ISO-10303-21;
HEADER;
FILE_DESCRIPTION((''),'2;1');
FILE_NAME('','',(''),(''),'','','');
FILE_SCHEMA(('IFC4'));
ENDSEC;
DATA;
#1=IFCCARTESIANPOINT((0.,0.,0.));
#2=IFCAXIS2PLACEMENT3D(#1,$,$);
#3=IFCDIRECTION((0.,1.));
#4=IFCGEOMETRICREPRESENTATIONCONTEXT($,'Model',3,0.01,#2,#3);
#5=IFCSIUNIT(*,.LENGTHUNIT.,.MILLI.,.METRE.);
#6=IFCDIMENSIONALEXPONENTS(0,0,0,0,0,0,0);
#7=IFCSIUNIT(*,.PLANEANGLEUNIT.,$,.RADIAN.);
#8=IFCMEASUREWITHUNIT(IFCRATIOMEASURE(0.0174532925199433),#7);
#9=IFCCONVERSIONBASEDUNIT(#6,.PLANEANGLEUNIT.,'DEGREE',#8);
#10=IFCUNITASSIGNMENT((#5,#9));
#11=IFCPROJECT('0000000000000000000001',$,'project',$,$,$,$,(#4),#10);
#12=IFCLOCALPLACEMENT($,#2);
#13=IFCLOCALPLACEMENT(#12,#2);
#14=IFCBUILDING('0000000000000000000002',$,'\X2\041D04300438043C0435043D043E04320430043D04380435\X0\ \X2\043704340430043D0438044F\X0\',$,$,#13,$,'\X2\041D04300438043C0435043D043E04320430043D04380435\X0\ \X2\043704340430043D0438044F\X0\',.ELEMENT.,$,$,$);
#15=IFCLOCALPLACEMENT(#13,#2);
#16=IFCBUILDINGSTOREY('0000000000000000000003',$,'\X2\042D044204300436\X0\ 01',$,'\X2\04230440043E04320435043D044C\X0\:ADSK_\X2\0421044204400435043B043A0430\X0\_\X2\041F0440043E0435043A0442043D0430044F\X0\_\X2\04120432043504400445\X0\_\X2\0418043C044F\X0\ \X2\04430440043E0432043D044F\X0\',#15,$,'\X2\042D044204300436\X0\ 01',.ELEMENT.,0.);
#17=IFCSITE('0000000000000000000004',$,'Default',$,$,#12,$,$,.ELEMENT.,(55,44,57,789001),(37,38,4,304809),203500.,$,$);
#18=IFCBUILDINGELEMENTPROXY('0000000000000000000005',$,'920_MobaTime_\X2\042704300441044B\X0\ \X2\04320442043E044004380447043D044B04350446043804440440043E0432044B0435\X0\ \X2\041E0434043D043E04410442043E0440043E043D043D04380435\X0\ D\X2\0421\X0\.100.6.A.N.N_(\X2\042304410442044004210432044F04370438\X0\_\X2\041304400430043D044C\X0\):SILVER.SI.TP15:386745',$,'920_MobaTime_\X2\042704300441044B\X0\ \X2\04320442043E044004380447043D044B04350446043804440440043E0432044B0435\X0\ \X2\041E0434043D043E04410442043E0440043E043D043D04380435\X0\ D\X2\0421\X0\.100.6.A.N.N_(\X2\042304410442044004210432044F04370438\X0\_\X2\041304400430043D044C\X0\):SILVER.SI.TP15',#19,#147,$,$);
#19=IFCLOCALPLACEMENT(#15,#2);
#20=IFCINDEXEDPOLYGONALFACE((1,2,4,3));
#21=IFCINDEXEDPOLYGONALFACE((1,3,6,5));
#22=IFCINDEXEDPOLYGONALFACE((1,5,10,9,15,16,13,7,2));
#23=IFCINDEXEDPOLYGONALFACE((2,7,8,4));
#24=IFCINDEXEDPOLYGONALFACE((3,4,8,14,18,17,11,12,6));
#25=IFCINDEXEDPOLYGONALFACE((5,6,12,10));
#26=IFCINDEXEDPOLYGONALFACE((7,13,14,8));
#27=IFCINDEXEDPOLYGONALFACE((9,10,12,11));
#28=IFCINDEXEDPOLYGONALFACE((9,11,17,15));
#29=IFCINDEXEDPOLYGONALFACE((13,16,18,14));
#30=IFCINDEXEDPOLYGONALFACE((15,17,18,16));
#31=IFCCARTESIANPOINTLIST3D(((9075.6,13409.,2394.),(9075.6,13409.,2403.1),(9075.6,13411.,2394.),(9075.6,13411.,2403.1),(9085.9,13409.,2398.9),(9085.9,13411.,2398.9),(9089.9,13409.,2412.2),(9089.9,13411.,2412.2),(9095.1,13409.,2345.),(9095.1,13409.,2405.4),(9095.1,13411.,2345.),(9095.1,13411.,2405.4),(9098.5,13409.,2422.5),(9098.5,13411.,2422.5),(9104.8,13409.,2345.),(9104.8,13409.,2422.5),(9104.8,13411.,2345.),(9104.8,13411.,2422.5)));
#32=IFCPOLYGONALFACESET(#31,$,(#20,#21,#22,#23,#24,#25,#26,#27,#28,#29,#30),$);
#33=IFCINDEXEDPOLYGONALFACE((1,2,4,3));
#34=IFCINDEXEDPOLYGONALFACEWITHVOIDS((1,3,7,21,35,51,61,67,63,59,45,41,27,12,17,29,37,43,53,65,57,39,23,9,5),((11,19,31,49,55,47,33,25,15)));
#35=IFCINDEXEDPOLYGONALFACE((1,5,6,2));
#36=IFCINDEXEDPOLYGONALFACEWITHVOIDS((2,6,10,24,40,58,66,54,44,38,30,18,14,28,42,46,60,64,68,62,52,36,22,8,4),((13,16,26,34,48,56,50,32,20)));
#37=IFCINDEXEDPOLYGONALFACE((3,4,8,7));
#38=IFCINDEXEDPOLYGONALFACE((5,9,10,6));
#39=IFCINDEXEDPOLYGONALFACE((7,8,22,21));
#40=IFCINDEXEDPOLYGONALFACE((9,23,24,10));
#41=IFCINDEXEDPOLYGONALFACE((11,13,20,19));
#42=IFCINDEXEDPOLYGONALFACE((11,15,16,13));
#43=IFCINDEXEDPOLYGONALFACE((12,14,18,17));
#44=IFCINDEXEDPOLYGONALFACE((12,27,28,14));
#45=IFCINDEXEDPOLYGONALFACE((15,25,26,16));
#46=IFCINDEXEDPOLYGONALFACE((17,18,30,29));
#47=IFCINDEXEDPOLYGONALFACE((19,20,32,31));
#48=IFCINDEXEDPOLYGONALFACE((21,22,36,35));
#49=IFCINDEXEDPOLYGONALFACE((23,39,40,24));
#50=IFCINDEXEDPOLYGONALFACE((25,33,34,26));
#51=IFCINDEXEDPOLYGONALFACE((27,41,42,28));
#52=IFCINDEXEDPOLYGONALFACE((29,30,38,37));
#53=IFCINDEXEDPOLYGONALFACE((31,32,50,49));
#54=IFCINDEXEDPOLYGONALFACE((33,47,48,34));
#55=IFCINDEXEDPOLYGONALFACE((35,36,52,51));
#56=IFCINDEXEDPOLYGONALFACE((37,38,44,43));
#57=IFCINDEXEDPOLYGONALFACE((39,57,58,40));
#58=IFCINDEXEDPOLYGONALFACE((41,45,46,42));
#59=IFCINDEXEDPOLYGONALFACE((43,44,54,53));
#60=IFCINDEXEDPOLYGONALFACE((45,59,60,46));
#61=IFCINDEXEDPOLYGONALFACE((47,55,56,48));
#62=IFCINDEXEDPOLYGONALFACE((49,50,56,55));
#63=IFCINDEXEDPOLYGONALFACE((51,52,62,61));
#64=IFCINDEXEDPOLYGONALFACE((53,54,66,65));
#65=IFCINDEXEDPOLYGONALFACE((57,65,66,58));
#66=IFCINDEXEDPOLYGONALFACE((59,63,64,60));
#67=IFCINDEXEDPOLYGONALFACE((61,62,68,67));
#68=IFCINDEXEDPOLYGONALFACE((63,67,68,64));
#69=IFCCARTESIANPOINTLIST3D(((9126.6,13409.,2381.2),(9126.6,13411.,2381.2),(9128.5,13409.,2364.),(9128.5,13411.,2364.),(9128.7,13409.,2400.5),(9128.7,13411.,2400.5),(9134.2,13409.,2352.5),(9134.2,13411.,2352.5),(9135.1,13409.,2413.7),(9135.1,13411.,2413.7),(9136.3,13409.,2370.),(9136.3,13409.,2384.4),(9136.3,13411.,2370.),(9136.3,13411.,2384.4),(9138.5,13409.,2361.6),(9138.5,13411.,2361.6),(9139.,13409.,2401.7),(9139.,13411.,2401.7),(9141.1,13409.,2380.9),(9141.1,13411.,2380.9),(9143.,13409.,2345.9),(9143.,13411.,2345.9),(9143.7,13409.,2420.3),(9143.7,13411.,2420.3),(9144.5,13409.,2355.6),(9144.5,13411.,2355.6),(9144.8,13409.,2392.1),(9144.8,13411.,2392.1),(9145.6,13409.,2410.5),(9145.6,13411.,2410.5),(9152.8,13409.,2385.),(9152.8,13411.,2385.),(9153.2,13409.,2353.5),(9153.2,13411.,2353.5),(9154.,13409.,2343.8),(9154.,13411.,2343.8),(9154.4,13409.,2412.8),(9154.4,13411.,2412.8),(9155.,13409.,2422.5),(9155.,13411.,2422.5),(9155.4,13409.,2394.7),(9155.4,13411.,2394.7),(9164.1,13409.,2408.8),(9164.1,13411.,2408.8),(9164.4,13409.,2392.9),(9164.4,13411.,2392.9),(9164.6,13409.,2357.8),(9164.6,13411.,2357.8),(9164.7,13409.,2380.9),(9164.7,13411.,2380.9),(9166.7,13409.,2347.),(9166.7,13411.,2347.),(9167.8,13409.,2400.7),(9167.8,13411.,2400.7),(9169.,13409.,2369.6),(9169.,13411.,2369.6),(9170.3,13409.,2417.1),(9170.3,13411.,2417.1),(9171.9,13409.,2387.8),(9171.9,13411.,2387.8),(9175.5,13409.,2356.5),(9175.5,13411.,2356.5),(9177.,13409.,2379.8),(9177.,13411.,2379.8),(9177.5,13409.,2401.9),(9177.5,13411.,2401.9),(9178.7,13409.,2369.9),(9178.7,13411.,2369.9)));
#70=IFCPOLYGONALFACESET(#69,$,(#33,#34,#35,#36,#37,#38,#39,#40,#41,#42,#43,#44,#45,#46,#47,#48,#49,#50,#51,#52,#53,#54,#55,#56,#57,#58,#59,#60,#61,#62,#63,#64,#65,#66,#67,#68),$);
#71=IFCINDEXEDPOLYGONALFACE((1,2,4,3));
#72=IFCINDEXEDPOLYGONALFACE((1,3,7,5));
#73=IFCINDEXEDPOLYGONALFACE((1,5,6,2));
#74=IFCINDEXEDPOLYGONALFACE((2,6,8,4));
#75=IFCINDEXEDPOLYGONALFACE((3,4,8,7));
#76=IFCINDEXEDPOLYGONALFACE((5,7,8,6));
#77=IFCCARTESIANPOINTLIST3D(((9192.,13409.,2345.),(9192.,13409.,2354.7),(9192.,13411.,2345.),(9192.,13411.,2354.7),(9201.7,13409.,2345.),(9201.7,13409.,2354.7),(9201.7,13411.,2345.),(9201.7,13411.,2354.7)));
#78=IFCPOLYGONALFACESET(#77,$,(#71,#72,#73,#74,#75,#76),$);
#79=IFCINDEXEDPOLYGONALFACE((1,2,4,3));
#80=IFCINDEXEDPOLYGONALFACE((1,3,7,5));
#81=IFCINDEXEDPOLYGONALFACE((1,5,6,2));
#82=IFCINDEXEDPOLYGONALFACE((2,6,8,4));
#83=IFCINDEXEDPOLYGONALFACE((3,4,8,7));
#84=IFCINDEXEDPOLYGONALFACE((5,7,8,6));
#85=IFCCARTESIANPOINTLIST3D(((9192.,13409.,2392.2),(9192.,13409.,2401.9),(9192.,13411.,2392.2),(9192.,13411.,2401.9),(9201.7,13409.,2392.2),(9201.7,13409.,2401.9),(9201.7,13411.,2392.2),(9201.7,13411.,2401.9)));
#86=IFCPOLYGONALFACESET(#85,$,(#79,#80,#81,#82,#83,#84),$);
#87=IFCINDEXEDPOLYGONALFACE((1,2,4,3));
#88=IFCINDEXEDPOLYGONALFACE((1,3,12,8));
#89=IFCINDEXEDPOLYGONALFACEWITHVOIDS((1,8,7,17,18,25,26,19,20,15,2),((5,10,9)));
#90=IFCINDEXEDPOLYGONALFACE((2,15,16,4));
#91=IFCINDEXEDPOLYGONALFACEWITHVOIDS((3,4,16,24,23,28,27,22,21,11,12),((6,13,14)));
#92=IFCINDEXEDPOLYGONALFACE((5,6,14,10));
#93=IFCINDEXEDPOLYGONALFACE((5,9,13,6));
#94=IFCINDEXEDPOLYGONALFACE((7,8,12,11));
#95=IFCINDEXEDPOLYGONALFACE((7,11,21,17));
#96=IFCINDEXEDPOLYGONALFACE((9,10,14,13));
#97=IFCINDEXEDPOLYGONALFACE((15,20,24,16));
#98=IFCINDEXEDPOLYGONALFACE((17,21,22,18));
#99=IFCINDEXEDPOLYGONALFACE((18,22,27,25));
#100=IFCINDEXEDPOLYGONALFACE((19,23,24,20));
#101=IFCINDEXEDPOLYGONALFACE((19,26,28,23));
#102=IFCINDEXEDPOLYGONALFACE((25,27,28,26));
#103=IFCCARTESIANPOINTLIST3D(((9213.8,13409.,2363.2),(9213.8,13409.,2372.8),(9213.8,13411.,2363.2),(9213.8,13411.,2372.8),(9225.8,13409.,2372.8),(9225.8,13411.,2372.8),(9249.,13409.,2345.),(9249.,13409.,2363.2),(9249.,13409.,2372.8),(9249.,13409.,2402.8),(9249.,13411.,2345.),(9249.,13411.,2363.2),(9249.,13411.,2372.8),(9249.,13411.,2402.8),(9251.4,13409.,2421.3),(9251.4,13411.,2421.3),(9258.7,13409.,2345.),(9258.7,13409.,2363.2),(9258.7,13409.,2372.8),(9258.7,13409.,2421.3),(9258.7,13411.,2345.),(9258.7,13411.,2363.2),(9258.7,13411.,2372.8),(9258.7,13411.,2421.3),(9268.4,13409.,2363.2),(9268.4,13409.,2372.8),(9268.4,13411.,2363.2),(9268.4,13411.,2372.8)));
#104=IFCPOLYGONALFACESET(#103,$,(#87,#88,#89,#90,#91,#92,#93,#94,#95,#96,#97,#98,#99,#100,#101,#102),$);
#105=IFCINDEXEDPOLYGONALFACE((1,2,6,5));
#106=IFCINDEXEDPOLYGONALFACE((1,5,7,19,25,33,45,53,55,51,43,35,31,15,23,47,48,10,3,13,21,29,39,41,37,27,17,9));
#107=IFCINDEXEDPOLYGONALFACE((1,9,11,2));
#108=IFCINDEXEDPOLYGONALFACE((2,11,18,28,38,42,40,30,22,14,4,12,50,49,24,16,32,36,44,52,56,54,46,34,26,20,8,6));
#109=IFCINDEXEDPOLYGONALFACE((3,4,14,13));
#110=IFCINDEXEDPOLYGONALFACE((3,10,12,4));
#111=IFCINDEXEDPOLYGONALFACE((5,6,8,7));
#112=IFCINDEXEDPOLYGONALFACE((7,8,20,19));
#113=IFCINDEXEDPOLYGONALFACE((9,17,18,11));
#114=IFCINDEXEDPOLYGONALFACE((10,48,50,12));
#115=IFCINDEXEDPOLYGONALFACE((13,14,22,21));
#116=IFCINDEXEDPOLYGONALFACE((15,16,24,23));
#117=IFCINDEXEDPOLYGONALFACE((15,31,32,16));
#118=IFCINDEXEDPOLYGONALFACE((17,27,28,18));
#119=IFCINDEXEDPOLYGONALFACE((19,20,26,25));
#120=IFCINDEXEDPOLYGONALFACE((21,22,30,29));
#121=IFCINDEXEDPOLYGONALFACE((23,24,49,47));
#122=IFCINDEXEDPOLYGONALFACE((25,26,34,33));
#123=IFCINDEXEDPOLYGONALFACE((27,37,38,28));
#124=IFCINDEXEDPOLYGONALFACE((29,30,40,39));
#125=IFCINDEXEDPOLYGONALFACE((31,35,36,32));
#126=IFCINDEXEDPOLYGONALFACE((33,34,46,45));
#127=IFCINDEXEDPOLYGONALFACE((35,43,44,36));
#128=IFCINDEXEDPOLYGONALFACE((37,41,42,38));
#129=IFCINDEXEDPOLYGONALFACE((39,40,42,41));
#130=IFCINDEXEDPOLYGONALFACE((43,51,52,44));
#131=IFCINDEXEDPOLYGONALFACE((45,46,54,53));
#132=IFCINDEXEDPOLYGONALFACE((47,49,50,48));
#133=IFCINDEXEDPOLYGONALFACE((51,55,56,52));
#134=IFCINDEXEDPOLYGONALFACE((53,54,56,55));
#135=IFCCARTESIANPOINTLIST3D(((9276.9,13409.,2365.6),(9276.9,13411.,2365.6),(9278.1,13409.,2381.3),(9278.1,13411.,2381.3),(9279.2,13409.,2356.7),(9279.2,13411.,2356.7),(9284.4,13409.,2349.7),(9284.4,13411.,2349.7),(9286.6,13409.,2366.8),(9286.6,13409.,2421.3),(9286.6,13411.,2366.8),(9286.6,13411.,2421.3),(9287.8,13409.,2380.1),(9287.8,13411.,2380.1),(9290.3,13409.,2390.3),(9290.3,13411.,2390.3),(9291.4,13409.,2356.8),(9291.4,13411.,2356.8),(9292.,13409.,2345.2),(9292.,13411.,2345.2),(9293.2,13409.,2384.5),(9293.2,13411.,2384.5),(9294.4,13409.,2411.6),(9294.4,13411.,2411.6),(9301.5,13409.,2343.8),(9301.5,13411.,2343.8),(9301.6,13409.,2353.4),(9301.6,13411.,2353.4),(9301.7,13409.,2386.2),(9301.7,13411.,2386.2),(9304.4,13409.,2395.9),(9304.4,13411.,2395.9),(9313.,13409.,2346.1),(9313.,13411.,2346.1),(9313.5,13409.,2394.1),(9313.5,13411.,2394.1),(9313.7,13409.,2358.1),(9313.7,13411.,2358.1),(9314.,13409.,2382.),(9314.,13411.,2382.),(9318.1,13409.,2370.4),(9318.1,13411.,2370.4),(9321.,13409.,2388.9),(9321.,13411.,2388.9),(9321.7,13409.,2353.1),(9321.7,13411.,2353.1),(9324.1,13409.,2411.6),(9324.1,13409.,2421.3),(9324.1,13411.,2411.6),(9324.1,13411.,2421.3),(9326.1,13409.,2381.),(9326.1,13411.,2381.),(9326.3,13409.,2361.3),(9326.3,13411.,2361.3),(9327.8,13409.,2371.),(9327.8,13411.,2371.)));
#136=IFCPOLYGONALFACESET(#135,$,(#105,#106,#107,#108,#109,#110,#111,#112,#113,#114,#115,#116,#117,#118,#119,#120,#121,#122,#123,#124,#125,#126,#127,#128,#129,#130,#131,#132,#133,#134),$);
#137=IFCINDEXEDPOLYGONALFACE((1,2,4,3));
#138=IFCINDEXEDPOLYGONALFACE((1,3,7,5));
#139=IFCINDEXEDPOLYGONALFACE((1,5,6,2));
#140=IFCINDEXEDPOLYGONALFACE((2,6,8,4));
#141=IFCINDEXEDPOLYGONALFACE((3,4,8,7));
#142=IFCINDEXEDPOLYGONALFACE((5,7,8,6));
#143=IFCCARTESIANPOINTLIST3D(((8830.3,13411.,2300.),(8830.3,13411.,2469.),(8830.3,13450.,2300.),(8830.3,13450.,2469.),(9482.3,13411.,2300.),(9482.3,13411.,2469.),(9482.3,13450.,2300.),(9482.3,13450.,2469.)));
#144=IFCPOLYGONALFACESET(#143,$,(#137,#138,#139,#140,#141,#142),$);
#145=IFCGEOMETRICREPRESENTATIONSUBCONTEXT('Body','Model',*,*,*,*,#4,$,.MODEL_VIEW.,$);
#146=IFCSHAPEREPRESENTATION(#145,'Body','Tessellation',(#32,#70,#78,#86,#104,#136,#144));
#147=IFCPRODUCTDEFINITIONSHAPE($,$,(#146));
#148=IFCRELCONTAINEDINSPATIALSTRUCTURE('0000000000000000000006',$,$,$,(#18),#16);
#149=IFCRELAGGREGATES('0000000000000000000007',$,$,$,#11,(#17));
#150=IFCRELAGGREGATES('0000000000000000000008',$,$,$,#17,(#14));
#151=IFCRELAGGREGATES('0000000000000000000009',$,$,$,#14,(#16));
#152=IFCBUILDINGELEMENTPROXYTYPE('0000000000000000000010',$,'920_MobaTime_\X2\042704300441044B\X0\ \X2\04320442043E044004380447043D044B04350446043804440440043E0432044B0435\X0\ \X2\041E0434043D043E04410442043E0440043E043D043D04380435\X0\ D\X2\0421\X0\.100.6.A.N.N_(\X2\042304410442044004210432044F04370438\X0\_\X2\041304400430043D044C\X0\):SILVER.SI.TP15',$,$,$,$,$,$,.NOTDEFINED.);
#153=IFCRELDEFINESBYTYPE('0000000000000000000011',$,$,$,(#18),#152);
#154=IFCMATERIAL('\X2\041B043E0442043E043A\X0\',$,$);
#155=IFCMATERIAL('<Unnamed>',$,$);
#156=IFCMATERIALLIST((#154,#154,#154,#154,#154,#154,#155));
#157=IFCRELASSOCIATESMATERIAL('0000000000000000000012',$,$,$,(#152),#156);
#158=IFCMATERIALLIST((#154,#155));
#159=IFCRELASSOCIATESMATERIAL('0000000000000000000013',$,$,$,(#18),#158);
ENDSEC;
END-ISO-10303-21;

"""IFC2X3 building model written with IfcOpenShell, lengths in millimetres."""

from ifc_helpers import new_model, entity, si_unit, converted_unit, direction, frame, origin, origin_2d_with_axis, place, context, subcontext, project, spatial, polyline, rectangle, outline, extrude, source, transform, mapped, material, material_list, type_object, type_shapes, element, save


model = new_model("IFC2X3")

# Units and contexts
model_context = context("Model", 3, precision=0.01, world=origin(), true_north=direction((0.0, 1.0)))
body_context = subcontext(model_context, "Body", "Model", "MODEL_VIEW")
ifc_project = project(units=[si_unit("LENGTHUNIT", "METRE", prefix="MILLI"), converted_unit("PLANEANGLEUNIT", "DEGREE", entity("IfcRatioMeasure", 0.0174532925199433), si_unit("PLANEANGLEUNIT", "RADIAN"), dimensions=[0, 0, 0, 0, 0, 0, 0])], contexts=[model_context])

# Site, building, storey
site_placement = place(None, origin())
site = spatial("IfcSite", under=ifc_project, at=site_placement, Name="Default", CompositionType="ELEMENT", RefLatitude=(55, 44, 57, 789001), RefLongitude=(37, 38, 4, 304809), RefElevation=203500.0)
building_placement = place(site_placement, origin())
building = spatial("IfcBuilding", under=site, at=building_placement, Name="Наименование здания", LongName="Наименование здания", CompositionType="ELEMENT")
storey_placement = place(building_placement, origin())
storey = spatial("IfcBuildingStorey", under=building, at=storey_placement, Name="Этаж 01", ObjectType="Уровень:ADSK_Стрелка_Проектная_Вверх_Имя уровня", LongName="Этаж 01", CompositionType="ELEMENT", Elevation=0.0)

# Building element proxy
ifc_material_1 = material(Name="Лоток")
ifc_material_2 = material(Name="<Unnamed>")
ifc_material_list_1 = material_list([ifc_material_1, ifc_material_1, ifc_material_1, ifc_material_1, ifc_material_1, ifc_material_1, ifc_material_2])
building_element_proxy_type = type_object("IfcBuildingElementProxyType", Name="920_MobaTime_Часы вторичныецифровые Односторонние DС.100.6.A.N.N_(УстрСвязи_Грань):SILVER.SI.TP15", PredefinedType="NOTDEFINED", material=ifc_material_list_1)
shared_shape = source(origin(), body_context, "Body", "SweptSolid", [
    extrude(outline(polyline([(-49.3, -13.1), (28.2, -13.1), (28.2, -6.8), (17.9, 1.8), (8.8, 16.0), (-0.3, 16.0), (4.6, 5.8), (11.1, -3.4), (-49.3, -3.4), (-49.3, -13.1)])), frame((-64.6, 9.8, 39.0), z_axis=(0.0, 0.0, 1.0), x_axis=(0.0, 1.0, 0.0)), (0.0, 0.0, 1.0), 2.0),
    extrude(outline(polyline([(2.2, -27.6), (19.0, -27.6), (30.5, -16.1), (33.3, -4.9), (31.0, 5.8), (21.8, 17.2), (5.2, 27.3), (-11.1, 33.0), (-24.0, 32.7), (-33.6, 27.6), (-40.3, 18.6), (-42.8, 5.7), (-38.0, -6.3), (-27.2, -14.9), (-17.5, -17.7), (-8.2, -16.4), (-0.3, -11.9), (5.1, -4.5), (7.3, 6.2), (4.0, 17.2), (18.4, 7.3), (23.6, -2.4), (22.0, -11.4), (14.2, -18.4), (5.3, -18.3), (2.2, -27.6)]), holes=[polyline([(-9.0, 23.3), (-1.3, 14.3), (-2.5, 2.0), (-11.4, -7.0), (-23.4, -6.0), (-32.2, 2.9), (-31.2, 15.1), (-25.6, 22.1), (-17.5, 24.9), (-9.0, 23.3)])]), frame((-2.7, 3.6, 39.0), z_axis=(0.0, 0.0, 1.0), x_axis=(-0.427649, 0.903945, 0.0)), (0.0, 0.0, 1.0), 2.0),
    extrude(rectangle(XDim=9.7, YDim=9.7, at=origin_2d_with_axis()), frame((40.6, -34.7, 39.0)), (0.0, 0.0, 1.0), 2.0),
    extrude(rectangle(XDim=9.7, YDim=9.7, at=origin_2d_with_axis()), frame((40.6, 12.6, 39.0)), (0.0, 0.0, 1.0), 2.0),
    extrude(outline(polyline([(-0.9, -28.1), (8.8, -28.1), (8.8, -9.9), (18.5, -9.9), (18.5, -0.2), (8.8, -0.2), (8.8, 48.3), (1.5, 48.3), (-36.0, -0.2), (-36.0, -9.9), (-0.9, -9.9), (-0.9, -28.1)]), holes=[polyline([(-0.9, -0.2), (-24.1, -0.2), (-0.9, 29.7), (-0.9, -0.2)])]), frame((93.6, -11.4, 39.0)), (0.0, 0.0, 1.0), 2.0),
    extrude(outline(polyline([(3.3, -28.3), (12.5, -28.3), (20.5, -25.0), (26.8, -18.9), (30.7, -10.0), (31.4, 1.6), (26.9, 11.8), (20.1, 18.4), (11.1, 22.3), (1.0, 23.3), (-7.9, 20.4), (-14.9, 14.5), (-18.9, 6.2), (-17.1, -9.0), (-36.7, 0.5), (-29.1, 29.2), (-38.5, 31.7), (-48.1, -4.6), (-11.6, -23.1), (-8.0, -14.0), (-10.8, -7.6), (-10.2, 1.1), (-3.0, 11.8), (9.2, 12.8), (20.0, 5.5), (21.4, -7.5), (15.5, -16.4), (4.6, -18.6), (3.3, -28.3)])), frame((147.1, -8.5, 39.0), z_axis=(0.0, 0.0, 1.0), x_axis=(0.256974, -0.966418, 0.0)), (0.0, 0.0, 1.0), 2.0),
    extrude(rectangle(XDim=652.0, YDim=169.0, at=origin_2d_with_axis()), frame((0.0, 0.0, 0.0), z_axis=(0.0, 0.0, 1.0), x_axis=(-1.0, 0.0, 0.0)), (0.0, 0.0, 1.0), 39.0),
])
type_shapes(building_element_proxy_type, [shared_shape])
ifc_material_list_2 = material_list([ifc_material_1, ifc_material_2])
for number, where, z_axis, x_axis, name in (
    (1, (9156.3, 13450.0, 2384.5), (0.0, -1.0, 0.0), (1.0, 0.0, 0.0), "920_MobaTime_Часы вторичныецифровые Односторонние DС.100.6.A.N.N_(УстрСвязи_Грань):SILVER.SI.TP15:386745"),
):
    element("IfcBuildingElementProxy", number, at=place(storey_placement, frame(where, z_axis=z_axis, x_axis=x_axis)), inside=storey, type_object=building_element_proxy_type, material=ifc_material_list_2, Name=name, ObjectType="920_MobaTime_Часы вторичныецифровые Односторонние DС.100.6.A.N.N_(УстрСвязи_Грань):SILVER.SI.TP15", context=body_context, shape_type="MappedRepresentation", body=[
        mapped(shared_shape, transform((0.0, 0.0, 0.0), scale=1.0)),
    ])

save(model, "model.ifc")
